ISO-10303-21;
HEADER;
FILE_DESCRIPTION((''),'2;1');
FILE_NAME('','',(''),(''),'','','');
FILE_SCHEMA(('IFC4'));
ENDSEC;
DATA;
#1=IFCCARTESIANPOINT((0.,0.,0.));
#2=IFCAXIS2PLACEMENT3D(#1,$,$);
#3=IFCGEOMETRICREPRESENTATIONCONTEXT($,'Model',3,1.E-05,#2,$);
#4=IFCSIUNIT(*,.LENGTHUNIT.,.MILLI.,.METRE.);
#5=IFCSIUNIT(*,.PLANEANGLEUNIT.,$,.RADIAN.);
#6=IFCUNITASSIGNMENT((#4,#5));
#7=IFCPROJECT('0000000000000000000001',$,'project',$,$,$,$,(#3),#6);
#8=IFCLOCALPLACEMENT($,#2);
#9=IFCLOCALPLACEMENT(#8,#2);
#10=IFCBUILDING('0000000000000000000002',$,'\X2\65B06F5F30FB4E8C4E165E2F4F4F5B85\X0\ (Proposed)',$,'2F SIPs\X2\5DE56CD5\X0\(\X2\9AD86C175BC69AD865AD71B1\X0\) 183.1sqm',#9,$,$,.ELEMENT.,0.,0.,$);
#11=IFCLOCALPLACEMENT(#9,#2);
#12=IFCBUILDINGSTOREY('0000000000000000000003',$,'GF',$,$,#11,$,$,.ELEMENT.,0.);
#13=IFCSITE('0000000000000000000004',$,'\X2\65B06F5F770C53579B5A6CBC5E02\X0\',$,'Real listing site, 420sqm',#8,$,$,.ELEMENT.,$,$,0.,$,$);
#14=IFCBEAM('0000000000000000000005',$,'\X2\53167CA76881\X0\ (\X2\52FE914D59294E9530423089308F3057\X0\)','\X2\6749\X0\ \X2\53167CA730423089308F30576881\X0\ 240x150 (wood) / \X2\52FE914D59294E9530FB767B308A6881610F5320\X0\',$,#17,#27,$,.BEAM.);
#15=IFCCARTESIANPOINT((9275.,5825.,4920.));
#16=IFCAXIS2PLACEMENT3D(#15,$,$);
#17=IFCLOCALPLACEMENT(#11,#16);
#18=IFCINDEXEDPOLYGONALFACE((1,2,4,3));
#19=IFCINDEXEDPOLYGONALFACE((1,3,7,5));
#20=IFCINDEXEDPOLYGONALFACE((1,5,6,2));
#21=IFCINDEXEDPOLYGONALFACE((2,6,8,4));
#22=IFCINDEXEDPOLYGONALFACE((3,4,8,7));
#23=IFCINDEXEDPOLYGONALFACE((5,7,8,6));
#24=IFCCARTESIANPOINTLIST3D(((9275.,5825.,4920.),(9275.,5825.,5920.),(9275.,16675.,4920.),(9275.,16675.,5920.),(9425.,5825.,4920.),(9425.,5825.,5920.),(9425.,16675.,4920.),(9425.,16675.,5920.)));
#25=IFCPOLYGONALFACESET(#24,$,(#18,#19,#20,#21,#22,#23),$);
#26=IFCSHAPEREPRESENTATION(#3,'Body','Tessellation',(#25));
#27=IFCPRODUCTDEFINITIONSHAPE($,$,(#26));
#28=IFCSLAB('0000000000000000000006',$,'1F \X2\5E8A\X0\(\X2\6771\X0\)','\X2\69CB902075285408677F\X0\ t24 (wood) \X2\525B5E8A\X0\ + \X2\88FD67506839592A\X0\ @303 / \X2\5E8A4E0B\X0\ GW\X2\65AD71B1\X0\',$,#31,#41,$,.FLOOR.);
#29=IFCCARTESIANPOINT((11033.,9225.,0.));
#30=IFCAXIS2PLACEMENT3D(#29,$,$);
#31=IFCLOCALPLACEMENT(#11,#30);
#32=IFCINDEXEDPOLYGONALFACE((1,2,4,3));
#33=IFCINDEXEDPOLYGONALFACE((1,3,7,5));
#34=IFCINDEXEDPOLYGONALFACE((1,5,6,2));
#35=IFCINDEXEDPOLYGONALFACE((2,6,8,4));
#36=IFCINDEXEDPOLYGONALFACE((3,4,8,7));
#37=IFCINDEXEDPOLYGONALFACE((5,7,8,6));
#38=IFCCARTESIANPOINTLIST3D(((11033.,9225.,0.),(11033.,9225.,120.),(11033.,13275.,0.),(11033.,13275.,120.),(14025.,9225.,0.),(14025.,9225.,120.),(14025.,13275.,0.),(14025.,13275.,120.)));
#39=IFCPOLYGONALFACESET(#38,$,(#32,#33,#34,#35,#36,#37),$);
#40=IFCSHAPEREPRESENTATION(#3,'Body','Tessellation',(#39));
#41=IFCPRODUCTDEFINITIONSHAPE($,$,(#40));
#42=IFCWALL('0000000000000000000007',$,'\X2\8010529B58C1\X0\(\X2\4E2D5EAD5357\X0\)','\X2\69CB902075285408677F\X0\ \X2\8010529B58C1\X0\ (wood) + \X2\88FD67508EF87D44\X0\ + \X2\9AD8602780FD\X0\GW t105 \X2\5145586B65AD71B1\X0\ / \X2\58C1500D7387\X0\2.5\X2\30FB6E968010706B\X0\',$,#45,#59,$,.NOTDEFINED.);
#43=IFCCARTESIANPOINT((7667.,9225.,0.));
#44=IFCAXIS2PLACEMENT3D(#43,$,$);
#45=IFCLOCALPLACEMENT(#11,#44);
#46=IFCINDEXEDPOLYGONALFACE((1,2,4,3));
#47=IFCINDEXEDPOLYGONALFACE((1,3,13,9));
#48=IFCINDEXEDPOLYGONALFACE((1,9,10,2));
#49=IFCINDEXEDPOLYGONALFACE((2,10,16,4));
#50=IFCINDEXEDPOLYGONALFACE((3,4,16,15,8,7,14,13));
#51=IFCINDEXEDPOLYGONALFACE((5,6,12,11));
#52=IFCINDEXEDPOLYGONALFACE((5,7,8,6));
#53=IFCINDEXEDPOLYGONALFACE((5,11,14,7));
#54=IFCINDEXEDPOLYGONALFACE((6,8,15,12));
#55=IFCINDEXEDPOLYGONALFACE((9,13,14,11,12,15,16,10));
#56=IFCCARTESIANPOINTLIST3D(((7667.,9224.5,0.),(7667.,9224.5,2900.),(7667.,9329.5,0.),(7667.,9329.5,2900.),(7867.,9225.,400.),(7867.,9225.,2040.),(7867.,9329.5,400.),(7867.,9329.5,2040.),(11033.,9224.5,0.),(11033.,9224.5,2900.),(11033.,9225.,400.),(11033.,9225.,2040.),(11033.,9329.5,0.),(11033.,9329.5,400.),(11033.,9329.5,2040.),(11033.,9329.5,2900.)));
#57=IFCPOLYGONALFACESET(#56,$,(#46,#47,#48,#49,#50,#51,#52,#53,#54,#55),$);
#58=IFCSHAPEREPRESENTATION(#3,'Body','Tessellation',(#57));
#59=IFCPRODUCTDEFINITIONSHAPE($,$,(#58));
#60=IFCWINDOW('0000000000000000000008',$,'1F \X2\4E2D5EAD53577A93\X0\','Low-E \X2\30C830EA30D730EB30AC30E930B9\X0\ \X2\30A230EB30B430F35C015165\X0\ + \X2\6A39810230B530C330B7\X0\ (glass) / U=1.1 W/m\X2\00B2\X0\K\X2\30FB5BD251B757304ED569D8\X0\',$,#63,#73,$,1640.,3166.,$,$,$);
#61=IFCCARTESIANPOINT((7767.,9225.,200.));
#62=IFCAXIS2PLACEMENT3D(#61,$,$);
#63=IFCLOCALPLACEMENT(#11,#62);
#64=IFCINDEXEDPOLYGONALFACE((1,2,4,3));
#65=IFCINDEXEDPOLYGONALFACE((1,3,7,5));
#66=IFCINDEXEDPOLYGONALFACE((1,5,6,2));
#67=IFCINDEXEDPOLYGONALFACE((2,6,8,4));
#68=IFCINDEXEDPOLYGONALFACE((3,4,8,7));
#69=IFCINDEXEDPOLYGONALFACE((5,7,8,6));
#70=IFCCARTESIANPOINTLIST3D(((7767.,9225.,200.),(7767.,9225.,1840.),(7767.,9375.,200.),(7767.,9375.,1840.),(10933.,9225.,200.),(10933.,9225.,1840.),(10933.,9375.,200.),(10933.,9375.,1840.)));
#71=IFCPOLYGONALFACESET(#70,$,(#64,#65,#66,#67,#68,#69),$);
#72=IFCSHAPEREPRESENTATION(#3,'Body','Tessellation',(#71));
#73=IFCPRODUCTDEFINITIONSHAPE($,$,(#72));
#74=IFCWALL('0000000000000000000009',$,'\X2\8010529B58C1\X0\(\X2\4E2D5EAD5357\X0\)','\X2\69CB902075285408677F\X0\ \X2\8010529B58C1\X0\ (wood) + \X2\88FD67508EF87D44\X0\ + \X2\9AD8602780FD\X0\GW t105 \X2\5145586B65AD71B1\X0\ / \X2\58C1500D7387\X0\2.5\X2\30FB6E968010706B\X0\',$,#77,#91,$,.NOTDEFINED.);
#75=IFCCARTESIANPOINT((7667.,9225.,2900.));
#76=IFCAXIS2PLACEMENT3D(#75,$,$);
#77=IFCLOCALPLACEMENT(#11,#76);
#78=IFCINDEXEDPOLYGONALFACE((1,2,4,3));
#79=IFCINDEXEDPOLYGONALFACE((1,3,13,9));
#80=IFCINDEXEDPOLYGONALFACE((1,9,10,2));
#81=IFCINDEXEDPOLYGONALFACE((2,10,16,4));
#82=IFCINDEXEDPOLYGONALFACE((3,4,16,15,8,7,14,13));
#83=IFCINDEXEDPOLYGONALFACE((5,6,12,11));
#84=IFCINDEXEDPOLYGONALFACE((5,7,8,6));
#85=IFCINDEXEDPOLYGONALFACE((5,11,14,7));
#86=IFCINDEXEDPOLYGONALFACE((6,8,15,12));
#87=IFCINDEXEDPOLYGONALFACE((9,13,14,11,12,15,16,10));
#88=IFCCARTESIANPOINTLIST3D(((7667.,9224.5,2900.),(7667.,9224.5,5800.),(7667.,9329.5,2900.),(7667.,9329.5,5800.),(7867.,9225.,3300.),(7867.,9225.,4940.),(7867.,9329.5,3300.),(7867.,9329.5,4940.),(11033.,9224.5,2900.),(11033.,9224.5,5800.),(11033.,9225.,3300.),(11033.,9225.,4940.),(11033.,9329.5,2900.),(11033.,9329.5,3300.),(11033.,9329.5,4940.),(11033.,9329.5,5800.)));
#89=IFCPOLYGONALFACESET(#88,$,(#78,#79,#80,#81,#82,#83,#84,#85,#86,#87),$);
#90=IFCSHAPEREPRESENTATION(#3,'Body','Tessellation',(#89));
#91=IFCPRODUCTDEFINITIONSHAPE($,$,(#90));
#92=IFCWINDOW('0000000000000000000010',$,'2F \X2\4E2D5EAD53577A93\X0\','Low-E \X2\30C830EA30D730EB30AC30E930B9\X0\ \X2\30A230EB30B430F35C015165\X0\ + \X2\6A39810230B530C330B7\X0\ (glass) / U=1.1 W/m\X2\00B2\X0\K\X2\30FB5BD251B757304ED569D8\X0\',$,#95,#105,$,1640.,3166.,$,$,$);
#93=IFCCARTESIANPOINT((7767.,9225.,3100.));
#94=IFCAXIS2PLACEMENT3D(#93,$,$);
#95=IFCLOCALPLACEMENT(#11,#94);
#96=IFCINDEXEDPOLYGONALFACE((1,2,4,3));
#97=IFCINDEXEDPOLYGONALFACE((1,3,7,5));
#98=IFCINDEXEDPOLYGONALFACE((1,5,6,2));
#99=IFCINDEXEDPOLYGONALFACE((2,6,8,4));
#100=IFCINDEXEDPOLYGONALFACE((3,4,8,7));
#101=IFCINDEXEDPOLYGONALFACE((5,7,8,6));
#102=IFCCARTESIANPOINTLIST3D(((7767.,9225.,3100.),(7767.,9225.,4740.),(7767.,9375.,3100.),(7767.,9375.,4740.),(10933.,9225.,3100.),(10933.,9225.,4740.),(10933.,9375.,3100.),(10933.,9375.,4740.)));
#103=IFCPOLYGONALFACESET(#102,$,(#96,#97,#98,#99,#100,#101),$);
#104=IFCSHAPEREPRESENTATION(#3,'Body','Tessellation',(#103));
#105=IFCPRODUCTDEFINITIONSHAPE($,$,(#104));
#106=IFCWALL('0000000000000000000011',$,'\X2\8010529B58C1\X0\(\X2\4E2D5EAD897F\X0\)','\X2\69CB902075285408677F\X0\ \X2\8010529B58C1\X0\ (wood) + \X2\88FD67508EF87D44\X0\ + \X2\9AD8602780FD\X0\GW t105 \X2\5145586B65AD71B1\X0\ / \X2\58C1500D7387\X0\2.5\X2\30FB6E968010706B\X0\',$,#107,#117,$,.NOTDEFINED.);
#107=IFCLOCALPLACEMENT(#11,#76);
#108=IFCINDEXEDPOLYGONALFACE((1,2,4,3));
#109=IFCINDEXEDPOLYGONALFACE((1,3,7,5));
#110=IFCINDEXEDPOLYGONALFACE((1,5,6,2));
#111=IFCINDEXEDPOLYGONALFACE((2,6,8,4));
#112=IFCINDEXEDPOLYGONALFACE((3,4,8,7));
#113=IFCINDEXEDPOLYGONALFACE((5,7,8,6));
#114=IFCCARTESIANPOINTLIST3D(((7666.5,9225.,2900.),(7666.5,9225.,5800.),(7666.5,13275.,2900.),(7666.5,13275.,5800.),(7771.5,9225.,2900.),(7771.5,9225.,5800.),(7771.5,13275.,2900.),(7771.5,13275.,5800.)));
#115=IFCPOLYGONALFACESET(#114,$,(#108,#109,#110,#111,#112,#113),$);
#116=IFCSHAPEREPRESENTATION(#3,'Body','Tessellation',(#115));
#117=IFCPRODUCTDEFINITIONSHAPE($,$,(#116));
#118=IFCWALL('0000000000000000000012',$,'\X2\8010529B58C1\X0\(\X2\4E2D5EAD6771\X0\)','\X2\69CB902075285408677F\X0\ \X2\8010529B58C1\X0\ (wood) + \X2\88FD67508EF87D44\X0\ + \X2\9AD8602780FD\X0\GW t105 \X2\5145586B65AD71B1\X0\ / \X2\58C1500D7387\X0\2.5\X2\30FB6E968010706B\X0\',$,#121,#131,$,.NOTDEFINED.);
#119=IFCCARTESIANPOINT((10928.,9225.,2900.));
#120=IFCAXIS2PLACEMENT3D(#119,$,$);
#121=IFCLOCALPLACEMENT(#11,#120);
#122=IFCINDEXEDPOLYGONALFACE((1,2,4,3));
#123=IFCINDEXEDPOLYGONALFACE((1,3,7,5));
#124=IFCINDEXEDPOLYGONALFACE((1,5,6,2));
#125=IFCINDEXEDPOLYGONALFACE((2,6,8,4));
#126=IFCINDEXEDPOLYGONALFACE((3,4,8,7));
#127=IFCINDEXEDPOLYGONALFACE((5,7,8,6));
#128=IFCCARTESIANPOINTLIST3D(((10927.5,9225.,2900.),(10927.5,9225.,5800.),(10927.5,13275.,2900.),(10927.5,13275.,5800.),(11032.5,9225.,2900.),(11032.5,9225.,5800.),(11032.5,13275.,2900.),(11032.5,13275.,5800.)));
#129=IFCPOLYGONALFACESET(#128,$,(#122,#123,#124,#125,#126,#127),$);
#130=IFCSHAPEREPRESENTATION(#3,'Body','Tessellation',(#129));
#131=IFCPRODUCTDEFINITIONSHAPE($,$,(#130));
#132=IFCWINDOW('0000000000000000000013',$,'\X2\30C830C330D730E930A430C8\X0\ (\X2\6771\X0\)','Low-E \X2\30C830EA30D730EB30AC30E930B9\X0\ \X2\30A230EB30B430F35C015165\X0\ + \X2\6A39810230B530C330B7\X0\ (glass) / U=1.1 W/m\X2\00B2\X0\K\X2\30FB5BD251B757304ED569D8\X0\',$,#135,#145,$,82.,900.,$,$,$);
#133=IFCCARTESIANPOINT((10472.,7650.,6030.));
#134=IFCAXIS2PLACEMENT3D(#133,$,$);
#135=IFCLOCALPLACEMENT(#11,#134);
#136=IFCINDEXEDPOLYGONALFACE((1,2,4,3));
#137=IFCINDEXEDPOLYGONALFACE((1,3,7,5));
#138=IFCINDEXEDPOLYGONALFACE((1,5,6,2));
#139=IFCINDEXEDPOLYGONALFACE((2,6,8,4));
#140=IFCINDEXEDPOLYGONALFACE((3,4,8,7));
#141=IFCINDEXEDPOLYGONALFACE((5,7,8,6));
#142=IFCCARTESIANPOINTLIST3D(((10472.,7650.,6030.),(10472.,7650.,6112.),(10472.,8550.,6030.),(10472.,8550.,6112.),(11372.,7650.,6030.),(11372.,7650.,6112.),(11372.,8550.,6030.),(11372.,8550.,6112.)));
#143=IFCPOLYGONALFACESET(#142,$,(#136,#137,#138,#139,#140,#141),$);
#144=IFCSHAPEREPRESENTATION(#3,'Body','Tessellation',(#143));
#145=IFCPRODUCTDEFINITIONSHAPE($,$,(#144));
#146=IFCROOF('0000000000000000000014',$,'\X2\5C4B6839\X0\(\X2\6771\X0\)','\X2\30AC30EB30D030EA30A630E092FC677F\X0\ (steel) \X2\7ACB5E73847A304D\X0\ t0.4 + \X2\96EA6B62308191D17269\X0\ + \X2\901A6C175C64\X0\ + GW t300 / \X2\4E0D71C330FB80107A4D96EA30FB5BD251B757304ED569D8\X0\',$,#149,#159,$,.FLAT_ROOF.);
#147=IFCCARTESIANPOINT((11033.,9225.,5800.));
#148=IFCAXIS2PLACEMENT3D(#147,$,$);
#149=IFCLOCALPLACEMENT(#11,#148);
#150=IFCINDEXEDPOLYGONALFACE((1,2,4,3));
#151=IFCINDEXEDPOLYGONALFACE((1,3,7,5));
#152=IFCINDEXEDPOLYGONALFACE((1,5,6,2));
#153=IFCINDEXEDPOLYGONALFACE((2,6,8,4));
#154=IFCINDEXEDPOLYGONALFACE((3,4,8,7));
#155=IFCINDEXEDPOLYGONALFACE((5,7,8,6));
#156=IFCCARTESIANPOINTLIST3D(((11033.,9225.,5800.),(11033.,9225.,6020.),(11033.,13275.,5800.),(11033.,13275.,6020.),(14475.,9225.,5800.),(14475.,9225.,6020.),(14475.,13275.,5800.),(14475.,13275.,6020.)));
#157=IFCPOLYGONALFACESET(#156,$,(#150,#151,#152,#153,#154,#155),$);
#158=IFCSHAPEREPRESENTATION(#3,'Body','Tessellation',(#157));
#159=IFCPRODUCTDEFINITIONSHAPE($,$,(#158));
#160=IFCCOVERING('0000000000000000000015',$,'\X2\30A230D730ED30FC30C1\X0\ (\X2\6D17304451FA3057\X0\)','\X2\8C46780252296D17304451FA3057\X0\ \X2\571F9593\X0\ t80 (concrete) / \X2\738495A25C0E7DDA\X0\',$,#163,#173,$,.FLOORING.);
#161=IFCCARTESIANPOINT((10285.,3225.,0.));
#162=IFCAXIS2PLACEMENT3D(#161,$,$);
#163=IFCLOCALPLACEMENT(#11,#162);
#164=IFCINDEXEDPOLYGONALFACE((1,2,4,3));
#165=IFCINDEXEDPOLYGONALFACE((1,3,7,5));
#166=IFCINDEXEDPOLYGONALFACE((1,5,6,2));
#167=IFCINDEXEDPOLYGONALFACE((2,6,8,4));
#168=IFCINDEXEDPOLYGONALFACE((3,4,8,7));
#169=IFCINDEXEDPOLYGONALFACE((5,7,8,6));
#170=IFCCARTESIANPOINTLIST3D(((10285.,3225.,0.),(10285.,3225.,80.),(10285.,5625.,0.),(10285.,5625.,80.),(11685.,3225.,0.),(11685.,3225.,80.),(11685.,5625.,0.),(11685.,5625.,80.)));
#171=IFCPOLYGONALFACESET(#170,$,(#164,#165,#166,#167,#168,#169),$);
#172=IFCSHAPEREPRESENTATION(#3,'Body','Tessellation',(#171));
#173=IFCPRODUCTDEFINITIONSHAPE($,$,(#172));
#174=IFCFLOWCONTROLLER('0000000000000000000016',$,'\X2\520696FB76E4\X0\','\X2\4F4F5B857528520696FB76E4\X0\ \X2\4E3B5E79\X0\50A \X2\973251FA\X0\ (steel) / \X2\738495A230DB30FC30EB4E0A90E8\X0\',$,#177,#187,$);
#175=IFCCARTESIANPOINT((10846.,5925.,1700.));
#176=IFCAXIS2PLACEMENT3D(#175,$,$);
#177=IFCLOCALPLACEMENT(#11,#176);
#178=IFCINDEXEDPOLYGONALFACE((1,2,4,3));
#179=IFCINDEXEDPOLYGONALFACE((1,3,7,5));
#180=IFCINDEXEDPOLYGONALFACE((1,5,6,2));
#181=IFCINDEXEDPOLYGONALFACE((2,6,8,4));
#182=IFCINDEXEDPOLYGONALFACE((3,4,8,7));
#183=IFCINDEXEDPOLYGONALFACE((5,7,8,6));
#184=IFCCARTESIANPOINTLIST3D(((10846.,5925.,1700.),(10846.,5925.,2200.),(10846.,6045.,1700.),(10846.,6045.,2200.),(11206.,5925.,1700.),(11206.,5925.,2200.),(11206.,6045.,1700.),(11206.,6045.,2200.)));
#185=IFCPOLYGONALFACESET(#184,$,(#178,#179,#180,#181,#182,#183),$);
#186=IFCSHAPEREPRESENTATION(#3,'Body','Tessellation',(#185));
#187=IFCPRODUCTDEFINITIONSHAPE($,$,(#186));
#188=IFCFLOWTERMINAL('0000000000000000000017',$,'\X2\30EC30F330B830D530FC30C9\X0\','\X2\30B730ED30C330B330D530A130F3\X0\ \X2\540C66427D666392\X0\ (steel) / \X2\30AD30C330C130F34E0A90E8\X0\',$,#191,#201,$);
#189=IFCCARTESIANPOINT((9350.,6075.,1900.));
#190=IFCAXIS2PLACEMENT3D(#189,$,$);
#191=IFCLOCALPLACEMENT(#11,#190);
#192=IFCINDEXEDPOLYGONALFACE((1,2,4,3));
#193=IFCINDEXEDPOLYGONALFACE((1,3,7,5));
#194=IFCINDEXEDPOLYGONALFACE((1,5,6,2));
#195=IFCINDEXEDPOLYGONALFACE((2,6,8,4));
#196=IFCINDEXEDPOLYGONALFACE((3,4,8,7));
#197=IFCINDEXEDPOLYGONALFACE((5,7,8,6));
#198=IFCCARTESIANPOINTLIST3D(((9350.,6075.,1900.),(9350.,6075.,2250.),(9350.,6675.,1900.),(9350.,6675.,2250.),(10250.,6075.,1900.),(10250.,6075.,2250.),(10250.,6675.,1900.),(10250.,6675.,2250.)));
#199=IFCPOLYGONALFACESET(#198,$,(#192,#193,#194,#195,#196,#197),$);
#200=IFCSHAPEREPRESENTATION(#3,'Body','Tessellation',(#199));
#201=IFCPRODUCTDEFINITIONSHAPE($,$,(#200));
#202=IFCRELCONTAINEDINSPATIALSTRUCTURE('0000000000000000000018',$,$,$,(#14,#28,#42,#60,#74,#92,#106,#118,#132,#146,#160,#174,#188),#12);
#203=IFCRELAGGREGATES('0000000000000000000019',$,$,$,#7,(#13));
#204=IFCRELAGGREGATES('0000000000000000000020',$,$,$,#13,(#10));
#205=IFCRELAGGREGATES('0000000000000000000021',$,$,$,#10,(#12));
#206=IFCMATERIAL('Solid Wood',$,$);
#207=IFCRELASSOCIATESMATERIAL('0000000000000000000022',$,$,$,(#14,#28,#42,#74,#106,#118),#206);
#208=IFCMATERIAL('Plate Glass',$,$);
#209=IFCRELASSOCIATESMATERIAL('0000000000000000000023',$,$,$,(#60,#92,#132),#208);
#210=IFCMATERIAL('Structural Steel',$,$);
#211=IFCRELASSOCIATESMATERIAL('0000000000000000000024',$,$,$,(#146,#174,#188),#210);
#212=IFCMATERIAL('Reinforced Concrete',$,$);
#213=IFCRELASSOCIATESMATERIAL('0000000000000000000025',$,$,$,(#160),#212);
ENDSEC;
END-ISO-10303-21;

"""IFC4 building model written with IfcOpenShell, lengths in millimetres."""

from ifc_helpers import new_model, si_unit, frame, frame_2d, origin, place, context, project, spatial, rectangle, extrude, material, element, fill, save


model = new_model("IFC4")

# Units and contexts
model_context = context("Model", 3, precision=1e-05, world=origin())
ifc_project = project(units=[si_unit("LENGTHUNIT", "METRE", prefix="MILLI"), si_unit("PLANEANGLEUNIT", "RADIAN")], contexts=[model_context])

# Site, building, storey
site_placement = place(None, origin())
site = spatial("IfcSite", under=ifc_project, at=site_placement, Name="新潟県南魚沼市", ObjectType="Real listing site, 420sqm", CompositionType="ELEMENT", RefElevation=0.0)
building_placement = place(site_placement, origin())
building = spatial("IfcBuilding", under=site, at=building_placement, Name="新潟・二世帯住宅 (Proposed)", ObjectType="2F SIPs工法(高気密高断熱) 183.1sqm", CompositionType="ELEMENT", ElevationOfRefHeight=0.0, ElevationOfTerrain=0.0)
storey_placement = place(building_placement, origin())
storey = spatial("IfcBuildingStorey", under=building, at=storey_placement, Name="GF", CompositionType="ELEMENT", Elevation=0.0)

# Shared definitions
ifc_material_1 = material(Name="Solid Wood")

# Beam
beam_placement = place(storey_placement, frame((9275.0, 5825.0, 4920.0)))
element("IfcBeam", 1, at=beam_placement, inside=storey, material=ifc_material_1, Name="化粧梁 (勾配天井あらわし)", Description="杉 化粧あらわし梁 240x150 (wood) / 勾配天井・登り梁意匠", PredefinedType="BEAM", context=model_context, shape_type="SweptSolid", body=[
    extrude(rectangle(XDim=150.0, YDim=10850.0, at=frame_2d((75.0, 5425.0))), frame((9275.0, 5825.0, 4920.0)), (0.0, 0.0, 1.0), 1000.0),
])

# Slab
slab_placement = place(storey_placement, frame((11033.0, 9225.0, 0.0)))
element("IfcSlab", 2, at=slab_placement, inside=storey, material=ifc_material_1, Name="1F 床(東)", Description="構造用合板 t24 (wood) 剛床 + 製材根太 @303 / 床下 GW断熱", PredefinedType="FLOOR", context=model_context, shape_type="SweptSolid", body=[
    extrude(rectangle(XDim=2992.0, YDim=4050.0, at=frame_2d((1496.0, 2025.0))), frame((11033.0, 9225.0, 0.0)), (0.0, 0.0, 1.0), 120.0),
])

# Wall, opening, window
wall_1_placement = place(storey_placement, frame((7667.0, 9225.0, 0.0)))
wall_1 = element("IfcWall", 3, at=wall_1_placement, inside=storey, material=ifc_material_1, Name="耐力壁(中庭南)", Description="構造用合板 耐力壁 (wood) + 製材軸組 + 高性能GW t105 充填断熱 / 壁倍率2.5・準耐火", PredefinedType="NOTDEFINED", context=model_context, shape_type="SweptSolid", body=[
    extrude(rectangle(XDim=3366.0, YDim=105.0, at=frame_2d((1683.0, 52.0))), frame((7667.0, 9225.0, 0.0)), (0.0, 0.0, 1.0), 2900.0),
])
opening_1_placement = place(storey_placement, frame((7767.0, 9225.0, 200.0)))
opening_1 = element("IfcOpeningElement", 4, at=opening_1_placement, cuts=wall_1, PredefinedType="NOTDEFINED", context=model_context, shape_type="SweptSolid", body=[
    extrude(rectangle(XDim=3166.0, YDim=150.0, at=frame_2d((1583.0, 75.0))), frame((7767.0, 9225.0, 200.0)), (0.0, 0.0, 1.0), 1640.0),
])
ifc_material_2 = material(Name="Plate Glass")
window_1_placement = place(storey_placement, frame((7767.0, 9225.0, 200.0)))
window_1 = element("IfcWindow", 5, at=window_1_placement, inside=storey, material=ifc_material_2, Name="1F 中庭南窓", Description="Low-E トリプルガラス アルゴン封入 + 樹脂サッシ (glass) / U=1.1 W/m²K・寒冷地仕様", OverallHeight=1640.0, OverallWidth=3166.0, context=model_context, shape_type="SweptSolid", body=[
    extrude(rectangle(XDim=3166.0, YDim=150.0, at=frame_2d((1583.0, 75.0))), frame((7767.0, 9225.0, 200.0)), (0.0, 0.0, 1.0), 1640.0),
])
fill(opening_1, window_1)

# Wall, opening, window
wall_2_placement = place(storey_placement, frame((7667.0, 9225.0, 2900.0)))
wall_2 = element("IfcWall", 6, at=wall_2_placement, inside=storey, material=ifc_material_1, Name="耐力壁(中庭南)", Description="構造用合板 耐力壁 (wood) + 製材軸組 + 高性能GW t105 充填断熱 / 壁倍率2.5・準耐火", PredefinedType="NOTDEFINED", context=model_context, shape_type="SweptSolid", body=[
    extrude(rectangle(XDim=3366.0, YDim=105.0, at=frame_2d((1683.0, 52.0))), frame((7667.0, 9225.0, 2900.0)), (0.0, 0.0, 1.0), 2900.0),
])
opening_2_placement = place(storey_placement, frame((7767.0, 9225.0, 3100.0)))
opening_2 = element("IfcOpeningElement", 7, at=opening_2_placement, cuts=wall_2, PredefinedType="NOTDEFINED", context=model_context, shape_type="SweptSolid", body=[
    extrude(rectangle(XDim=3166.0, YDim=150.0, at=frame_2d((1583.0, 75.0))), frame((7767.0, 9225.0, 3100.0)), (0.0, 0.0, 1.0), 1640.0),
])
window_2_placement = place(storey_placement, frame((7767.0, 9225.0, 3100.0)))
window_2 = element("IfcWindow", 8, at=window_2_placement, inside=storey, material=ifc_material_2, Name="2F 中庭南窓", Description="Low-E トリプルガラス アルゴン封入 + 樹脂サッシ (glass) / U=1.1 W/m²K・寒冷地仕様", OverallHeight=1640.0, OverallWidth=3166.0, context=model_context, shape_type="SweptSolid", body=[
    extrude(rectangle(XDim=3166.0, YDim=150.0, at=frame_2d((1583.0, 75.0))), frame((7767.0, 9225.0, 3100.0)), (0.0, 0.0, 1.0), 1640.0),
])
fill(opening_2, window_2)

# Walls
wall_3_placement = place(storey_placement, frame((7667.0, 9225.0, 2900.0)))
element("IfcWall", 9, at=wall_3_placement, inside=storey, material=ifc_material_1, Name="耐力壁(中庭西)", Description="構造用合板 耐力壁 (wood) + 製材軸組 + 高性能GW t105 充填断熱 / 壁倍率2.5・準耐火", PredefinedType="NOTDEFINED", context=model_context, shape_type="SweptSolid", body=[
    extrude(rectangle(XDim=105.0, YDim=4050.0, at=frame_2d((52.0, 2025.0))), frame((7667.0, 9225.0, 2900.0)), (0.0, 0.0, 1.0), 2900.0),
])
wall_4_placement = place(storey_placement, frame((10928.0, 9225.0, 2900.0)))
element("IfcWall", 10, at=wall_4_placement, inside=storey, material=ifc_material_1, Name="耐力壁(中庭東)", Description="構造用合板 耐力壁 (wood) + 製材軸組 + 高性能GW t105 充填断熱 / 壁倍率2.5・準耐火", PredefinedType="NOTDEFINED", context=model_context, shape_type="SweptSolid", body=[
    extrude(rectangle(XDim=105.0, YDim=4050.0, at=frame_2d((52.0, 2025.0))), frame((10928.0, 9225.0, 2900.0)), (0.0, 0.0, 1.0), 2900.0),
])

# Window
window_3_placement = place(storey_placement, frame((10472.0, 7650.0, 6030.0)))
element("IfcWindow", 11, at=window_3_placement, inside=storey, material=ifc_material_2, Name="トップライト (東)", Description="Low-E トリプルガラス アルゴン封入 + 樹脂サッシ (glass) / U=1.1 W/m²K・寒冷地仕様", OverallHeight=82.0, OverallWidth=900.0, context=model_context, shape_type="SweptSolid", body=[
    extrude(rectangle(XDim=900.0, YDim=900.0, at=frame_2d((450.0, 450.0))), frame((10472.0, 7650.0, 6030.0)), (0.0, 0.0, 1.0), 82.0),
])

# Roof
ifc_material_3 = material(Name="Structural Steel")
roof_placement = place(storey_placement, frame((11033.0, 9225.0, 5800.0)))
element("IfcRoof", 12, at=roof_placement, inside=storey, material=ifc_material_3, Name="屋根(東)", Description="ガルバリウム鋼板 (steel) 立平葺き t0.4 + 雪止め金物 + 通気層 + GW t300 / 不燃・耐積雪・寒冷地仕様", PredefinedType="FLAT_ROOF", context=model_context, shape_type="SweptSolid", body=[
    extrude(rectangle(XDim=3442.0, YDim=4050.0, at=frame_2d((1721.0, 2025.0))), frame((11033.0, 9225.0, 5800.0)), (0.0, 0.0, 1.0), 220.0),
])

# Covering
ifc_material_4 = material(Name="Reinforced Concrete")
covering_placement = place(storey_placement, frame((10285.0, 3225.0, 0.0)))
element("IfcCovering", 13, at=covering_placement, inside=storey, material=ifc_material_4, Name="アプローチ (洗い出し)", Description="豆砂利洗い出し 土間 t80 (concrete) / 玄関導線", PredefinedType="FLOORING", context=model_context, shape_type="SweptSolid", body=[
    extrude(rectangle(XDim=1400.0, YDim=2400.0, at=frame_2d((700.0, 1200.0))), frame((10285.0, 3225.0, 0.0)), (0.0, 0.0, 1.0), 80.0),
])

# Flow controller
flow_controller_placement = place(storey_placement, frame((10846.0, 5925.0, 1700.0)))
element("IfcFlowController", 14, at=flow_controller_placement, inside=storey, material=ifc_material_3, Name="分電盤", Description="住宅用分電盤 主幹50A 露出 (steel) / 玄関ホール上部", context=model_context, shape_type="SweptSolid", body=[
    extrude(rectangle(XDim=360.0, YDim=120.0, at=frame_2d((180.0, 60.0))), frame((10846.0, 5925.0, 1700.0)), (0.0, 0.0, 1.0), 500.0),
])

# Flow terminal
flow_terminal_1_placement = place(storey_placement, frame((9350.0, 6075.0, 1900.0)))
element("IfcFlowTerminal", 15, at=flow_terminal_1_placement, inside=storey, material=ifc_material_3, Name="レンジフード", Description="シロッコファン 同時給排 (steel) / キッチン上部", context=model_context, shape_type="SweptSolid", body=[
    extrude(rectangle(XDim=900.0, YDim=600.0, at=frame_2d((450.0, 300.0))), frame((9350.0, 6075.0, 1900.0)), (0.0, 0.0, 1.0), 350.0),
])

save(model, "model.ifc")
